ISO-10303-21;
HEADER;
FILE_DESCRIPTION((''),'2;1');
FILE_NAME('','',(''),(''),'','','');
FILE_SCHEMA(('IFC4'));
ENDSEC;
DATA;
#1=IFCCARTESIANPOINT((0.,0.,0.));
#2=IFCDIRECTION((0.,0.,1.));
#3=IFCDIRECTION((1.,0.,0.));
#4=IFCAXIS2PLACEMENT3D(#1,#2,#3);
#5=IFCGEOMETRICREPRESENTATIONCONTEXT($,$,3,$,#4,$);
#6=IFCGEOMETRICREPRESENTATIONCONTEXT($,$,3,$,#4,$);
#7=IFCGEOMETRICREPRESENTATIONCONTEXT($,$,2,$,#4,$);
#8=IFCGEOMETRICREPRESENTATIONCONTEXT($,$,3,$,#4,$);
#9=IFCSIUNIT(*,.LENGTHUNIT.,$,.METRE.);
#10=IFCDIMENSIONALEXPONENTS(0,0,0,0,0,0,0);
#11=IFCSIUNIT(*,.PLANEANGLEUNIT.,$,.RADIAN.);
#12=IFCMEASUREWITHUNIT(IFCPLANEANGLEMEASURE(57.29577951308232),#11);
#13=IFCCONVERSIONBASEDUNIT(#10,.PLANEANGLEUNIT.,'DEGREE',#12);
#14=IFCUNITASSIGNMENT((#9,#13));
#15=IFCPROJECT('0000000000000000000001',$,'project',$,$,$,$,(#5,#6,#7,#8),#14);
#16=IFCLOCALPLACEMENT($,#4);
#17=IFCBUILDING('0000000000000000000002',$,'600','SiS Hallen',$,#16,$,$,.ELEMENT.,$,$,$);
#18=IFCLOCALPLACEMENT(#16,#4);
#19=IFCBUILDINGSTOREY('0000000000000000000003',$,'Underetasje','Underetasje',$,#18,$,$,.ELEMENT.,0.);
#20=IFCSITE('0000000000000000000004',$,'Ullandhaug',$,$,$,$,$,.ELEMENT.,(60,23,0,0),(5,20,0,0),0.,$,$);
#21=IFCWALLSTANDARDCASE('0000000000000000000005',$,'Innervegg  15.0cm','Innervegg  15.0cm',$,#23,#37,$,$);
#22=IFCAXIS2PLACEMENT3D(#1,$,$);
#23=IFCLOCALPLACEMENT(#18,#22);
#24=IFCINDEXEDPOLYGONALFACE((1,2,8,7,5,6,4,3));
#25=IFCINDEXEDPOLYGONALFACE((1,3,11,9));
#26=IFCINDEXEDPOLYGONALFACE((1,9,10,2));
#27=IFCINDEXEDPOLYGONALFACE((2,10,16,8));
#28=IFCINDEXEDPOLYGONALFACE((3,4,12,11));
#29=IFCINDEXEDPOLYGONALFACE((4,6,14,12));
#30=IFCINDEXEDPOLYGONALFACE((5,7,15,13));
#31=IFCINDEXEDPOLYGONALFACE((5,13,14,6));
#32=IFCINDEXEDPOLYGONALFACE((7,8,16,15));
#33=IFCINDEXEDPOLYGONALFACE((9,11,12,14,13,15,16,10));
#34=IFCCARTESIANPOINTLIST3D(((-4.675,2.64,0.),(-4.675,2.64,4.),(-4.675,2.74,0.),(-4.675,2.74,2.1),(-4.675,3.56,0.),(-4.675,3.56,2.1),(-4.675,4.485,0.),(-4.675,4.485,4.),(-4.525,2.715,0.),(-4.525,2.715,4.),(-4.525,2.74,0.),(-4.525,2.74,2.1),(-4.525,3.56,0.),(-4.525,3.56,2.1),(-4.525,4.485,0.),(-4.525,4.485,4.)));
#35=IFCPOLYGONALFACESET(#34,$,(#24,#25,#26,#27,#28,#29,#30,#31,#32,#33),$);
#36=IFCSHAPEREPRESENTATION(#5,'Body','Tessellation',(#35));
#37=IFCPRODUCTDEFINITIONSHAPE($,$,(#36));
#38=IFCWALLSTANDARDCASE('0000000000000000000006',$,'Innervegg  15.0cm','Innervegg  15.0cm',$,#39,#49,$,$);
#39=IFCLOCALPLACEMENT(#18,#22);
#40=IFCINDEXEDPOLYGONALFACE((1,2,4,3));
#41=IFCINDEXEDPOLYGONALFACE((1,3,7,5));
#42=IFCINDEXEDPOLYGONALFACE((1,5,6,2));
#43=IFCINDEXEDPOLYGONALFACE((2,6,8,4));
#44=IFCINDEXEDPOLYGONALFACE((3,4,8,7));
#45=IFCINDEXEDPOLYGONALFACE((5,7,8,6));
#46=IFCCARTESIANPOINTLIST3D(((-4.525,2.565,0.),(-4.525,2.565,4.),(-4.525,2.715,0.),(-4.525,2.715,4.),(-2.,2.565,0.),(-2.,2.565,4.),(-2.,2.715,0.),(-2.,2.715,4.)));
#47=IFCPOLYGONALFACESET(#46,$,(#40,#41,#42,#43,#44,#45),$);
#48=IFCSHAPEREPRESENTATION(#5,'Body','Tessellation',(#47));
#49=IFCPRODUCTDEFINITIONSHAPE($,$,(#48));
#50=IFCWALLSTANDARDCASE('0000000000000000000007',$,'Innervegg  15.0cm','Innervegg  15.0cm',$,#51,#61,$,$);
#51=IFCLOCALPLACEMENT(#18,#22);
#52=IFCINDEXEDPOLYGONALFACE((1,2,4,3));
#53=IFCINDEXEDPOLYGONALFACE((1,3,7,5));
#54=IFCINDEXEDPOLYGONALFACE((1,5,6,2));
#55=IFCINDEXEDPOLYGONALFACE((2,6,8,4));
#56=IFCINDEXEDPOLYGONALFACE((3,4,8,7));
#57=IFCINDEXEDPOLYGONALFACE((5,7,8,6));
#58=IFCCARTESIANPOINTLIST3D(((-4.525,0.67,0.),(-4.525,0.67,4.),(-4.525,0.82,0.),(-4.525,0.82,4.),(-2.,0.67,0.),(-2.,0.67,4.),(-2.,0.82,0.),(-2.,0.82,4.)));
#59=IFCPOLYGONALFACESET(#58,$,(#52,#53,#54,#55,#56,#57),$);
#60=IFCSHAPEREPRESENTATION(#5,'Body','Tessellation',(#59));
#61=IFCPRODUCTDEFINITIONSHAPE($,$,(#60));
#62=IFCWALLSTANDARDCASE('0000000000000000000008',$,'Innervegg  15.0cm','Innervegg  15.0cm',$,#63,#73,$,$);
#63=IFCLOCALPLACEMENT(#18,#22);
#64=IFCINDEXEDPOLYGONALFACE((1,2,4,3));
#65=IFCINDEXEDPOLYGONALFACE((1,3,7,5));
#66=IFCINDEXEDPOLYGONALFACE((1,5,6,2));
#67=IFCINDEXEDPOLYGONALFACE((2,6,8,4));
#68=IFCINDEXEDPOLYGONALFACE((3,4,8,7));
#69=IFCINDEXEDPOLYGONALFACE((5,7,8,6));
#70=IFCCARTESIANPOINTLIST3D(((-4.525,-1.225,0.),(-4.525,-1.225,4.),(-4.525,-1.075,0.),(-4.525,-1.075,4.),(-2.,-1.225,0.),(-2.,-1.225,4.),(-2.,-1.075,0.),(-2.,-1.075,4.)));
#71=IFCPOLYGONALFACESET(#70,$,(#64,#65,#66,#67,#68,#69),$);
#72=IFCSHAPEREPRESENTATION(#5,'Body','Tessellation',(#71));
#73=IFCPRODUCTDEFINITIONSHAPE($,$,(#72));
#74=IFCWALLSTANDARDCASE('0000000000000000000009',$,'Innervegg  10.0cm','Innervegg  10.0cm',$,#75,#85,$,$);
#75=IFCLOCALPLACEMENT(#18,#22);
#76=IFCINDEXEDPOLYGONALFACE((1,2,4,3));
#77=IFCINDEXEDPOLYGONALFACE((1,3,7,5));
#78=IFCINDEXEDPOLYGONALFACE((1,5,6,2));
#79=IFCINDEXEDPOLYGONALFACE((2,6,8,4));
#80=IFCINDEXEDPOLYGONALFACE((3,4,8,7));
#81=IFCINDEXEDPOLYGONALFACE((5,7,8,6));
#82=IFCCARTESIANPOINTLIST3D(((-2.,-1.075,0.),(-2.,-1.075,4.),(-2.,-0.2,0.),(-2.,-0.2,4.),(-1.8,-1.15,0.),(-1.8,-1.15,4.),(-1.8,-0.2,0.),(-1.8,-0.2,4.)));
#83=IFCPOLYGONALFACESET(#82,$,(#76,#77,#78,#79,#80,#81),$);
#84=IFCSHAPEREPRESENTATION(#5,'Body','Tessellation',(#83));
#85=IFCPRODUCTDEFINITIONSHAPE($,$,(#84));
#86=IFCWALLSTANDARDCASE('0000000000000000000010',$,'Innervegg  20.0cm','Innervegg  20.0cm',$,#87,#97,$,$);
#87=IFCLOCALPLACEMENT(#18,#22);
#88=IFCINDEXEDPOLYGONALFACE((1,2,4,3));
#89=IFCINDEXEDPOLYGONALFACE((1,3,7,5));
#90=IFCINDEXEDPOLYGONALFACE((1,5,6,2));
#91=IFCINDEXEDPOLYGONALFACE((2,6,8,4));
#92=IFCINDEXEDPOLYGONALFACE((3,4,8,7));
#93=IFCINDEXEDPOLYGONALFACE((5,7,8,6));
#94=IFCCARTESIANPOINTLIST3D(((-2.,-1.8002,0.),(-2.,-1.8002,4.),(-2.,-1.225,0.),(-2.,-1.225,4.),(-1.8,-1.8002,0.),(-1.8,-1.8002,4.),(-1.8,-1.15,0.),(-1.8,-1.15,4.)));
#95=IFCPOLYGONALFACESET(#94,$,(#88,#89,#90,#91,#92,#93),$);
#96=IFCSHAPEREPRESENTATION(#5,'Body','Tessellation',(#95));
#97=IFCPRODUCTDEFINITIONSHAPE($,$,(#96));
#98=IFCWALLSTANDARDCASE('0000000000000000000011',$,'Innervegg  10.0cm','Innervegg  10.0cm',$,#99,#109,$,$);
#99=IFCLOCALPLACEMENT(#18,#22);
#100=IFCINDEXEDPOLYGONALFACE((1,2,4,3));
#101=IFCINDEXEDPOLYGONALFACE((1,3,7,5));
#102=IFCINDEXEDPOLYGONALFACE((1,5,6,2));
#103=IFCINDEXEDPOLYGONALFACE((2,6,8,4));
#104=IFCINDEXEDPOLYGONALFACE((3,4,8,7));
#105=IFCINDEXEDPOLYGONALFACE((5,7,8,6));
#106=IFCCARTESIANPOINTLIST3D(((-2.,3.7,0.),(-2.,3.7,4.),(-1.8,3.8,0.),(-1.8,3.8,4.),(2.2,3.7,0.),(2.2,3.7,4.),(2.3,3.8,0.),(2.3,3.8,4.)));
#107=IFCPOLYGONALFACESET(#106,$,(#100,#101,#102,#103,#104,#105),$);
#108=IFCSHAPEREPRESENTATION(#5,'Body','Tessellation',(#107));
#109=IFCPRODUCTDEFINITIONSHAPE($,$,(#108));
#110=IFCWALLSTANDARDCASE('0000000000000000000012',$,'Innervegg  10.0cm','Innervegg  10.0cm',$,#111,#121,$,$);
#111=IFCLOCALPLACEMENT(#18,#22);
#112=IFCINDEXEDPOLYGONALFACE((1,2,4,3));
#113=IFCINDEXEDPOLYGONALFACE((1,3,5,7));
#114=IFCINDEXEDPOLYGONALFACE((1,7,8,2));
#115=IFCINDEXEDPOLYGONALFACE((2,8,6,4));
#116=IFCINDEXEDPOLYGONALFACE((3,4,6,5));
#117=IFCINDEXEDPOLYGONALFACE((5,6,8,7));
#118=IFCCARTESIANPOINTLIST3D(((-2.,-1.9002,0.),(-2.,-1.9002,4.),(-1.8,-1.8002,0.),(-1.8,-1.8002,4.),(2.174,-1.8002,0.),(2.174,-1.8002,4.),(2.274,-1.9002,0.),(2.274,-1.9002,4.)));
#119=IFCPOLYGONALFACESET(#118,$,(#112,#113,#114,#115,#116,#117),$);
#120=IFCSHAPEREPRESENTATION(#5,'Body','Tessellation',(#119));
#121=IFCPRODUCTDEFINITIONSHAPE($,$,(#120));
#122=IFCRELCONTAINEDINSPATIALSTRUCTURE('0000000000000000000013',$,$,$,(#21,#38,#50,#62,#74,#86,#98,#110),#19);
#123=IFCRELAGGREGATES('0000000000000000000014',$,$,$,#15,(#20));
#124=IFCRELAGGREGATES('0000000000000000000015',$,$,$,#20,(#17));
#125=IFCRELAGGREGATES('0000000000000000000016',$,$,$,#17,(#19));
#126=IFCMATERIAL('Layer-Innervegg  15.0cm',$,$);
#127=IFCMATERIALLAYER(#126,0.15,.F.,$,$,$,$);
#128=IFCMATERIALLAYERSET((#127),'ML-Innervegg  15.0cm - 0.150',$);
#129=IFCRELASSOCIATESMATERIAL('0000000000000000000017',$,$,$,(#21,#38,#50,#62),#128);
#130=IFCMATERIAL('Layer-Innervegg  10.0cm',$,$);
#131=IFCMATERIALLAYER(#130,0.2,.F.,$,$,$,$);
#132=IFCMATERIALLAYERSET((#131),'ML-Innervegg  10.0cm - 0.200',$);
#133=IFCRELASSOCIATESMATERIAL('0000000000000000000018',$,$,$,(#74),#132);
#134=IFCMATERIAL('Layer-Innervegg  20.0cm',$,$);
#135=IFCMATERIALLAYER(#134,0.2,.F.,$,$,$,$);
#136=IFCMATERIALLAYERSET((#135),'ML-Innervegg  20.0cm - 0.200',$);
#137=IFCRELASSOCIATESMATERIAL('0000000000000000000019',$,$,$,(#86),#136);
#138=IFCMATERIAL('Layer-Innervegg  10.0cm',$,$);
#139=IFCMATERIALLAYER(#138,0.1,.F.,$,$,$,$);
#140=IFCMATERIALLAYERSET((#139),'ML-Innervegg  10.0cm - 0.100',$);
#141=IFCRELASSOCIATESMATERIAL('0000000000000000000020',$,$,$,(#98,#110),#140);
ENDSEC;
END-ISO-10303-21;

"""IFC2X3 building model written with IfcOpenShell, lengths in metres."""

from ifc_helpers import new_model, entity, si_unit, converted_unit, frame, origin_with_axes, place, context, project, spatial, polyline, outline, extrude, material, layer, layer_set, layer_usage, element, save


model = new_model("IFC2X3")

# Units and contexts
context_of_model_1 = context(None, 3, world=origin_with_axes())
context_of_model_2 = context(None, 3, world=origin_with_axes())
context_of_model_3 = context(None, 2, world=origin_with_axes())
context_of_model_4 = context(None, 3, world=origin_with_axes())
ifc_project = project(units=[si_unit("LENGTHUNIT", "METRE"), converted_unit("PLANEANGLEUNIT", "DEGREE", entity("IfcPlaneAngleMeasure", 57.29577951308232), si_unit("PLANEANGLEUNIT", "RADIAN"), dimensions=[0, 0, 0, 0, 0, 0, 0])], contexts=[context_of_model_1, context_of_model_2, context_of_model_3, context_of_model_4])

# Site, building, storey
site = spatial("IfcSite", under=ifc_project, Name="Ullandhaug", CompositionType="ELEMENT", RefLatitude=(60, 23, 0, 0), RefLongitude=(5, 20, 0, 0), RefElevation=0.0)
building_placement = place(None, origin_with_axes())
building = spatial("IfcBuilding", under=site, at=building_placement, Name="600", Description="SiS Hallen", CompositionType="ELEMENT")
storey_placement = place(building_placement, origin_with_axes())
storey = spatial("IfcBuildingStorey", under=building, at=storey_placement, Name="Underetasje", Description="Underetasje", CompositionType="ELEMENT", Elevation=0.0)

# Shared definitions
ifc_material_1 = material(Name="Layer-Innervegg  15.0cm")
ifc_layer_1 = layer(ifc_material_1, 0.15, ventilated=False)
ifc_layer_set_1 = layer_set([ifc_layer_1], Name="ML-Innervegg  15.0cm - 0.150")
ifc_layer_usage_1 = layer_usage(ifc_layer_set_1, "AXIS2", "POSITIVE", 0.0)

# Shared definitions
ifc_material_2 = material(Name="Layer-Innervegg  10.0cm")
ifc_layer_2 = layer(ifc_material_2, 0.1, ventilated=False)
ifc_layer_set_2 = layer_set([ifc_layer_2], Name="ML-Innervegg  10.0cm - 0.100")
ifc_layer_usage_2 = layer_usage(ifc_layer_set_2, "AXIS2", "POSITIVE", 0.0)

# Wall, opening
wall_1_placement = place(storey_placement, frame((-4.525, 2.715, 0.0), z_axis=(0.0, 0.0, 1.0), x_axis=(0.0, 1.0, 0.0)))
wall_1 = element("IfcWallStandardCase", 1, at=wall_1_placement, inside=storey, material=ifc_layer_usage_1, Name="Innervegg  15.0cm", Description="Innervegg  15.0cm", context=context_of_model_1, shape_type="SweptSolid", body=[
    extrude(outline(polyline([(0.0, 0.0), (1.77, 0.0), (1.77, 0.15), (-0.075, 0.15), (0.0, 0.0)])), frame((0.0, 0.0, 0.0), z_axis=(0.0, 0.0, 1.0), x_axis=(1.0, 0.0, 0.0)), (0.0, 0.0, 1.0), 4.0),
])
opening_1_placement = place(wall_1_placement, frame((0.025, 0.15, 0.0), z_axis=(0.0, 0.0, 1.0), x_axis=(1.0, 0.0, 0.0)))
element("IfcOpeningElement", 2, at=opening_1_placement, cuts=wall_1, context=context_of_model_1, shape_type="SweptSolid", body=[
    extrude(outline(polyline([(0.0, 0.0), (2.1, 0.0), (2.1, 0.82), (0.0, 0.82), (0.0, 0.0)])), frame((0.0, 0.0, 0.0), z_axis=(0.0, 1.0, 0.0), x_axis=(0.0, 0.0, 1.0)), (0.0, 0.0, -1.0), 0.15),
])

# Walls
wall_2_placement = place(storey_placement, frame((-4.525, 2.565, 0.0), z_axis=(0.0, 0.0, 1.0), x_axis=(1.0, 0.0, 0.0)))
element("IfcWallStandardCase", 3, at=wall_2_placement, inside=storey, material=ifc_layer_usage_1, Name="Innervegg  15.0cm", Description="Innervegg  15.0cm", context=context_of_model_1, shape_type="SweptSolid", body=[
    extrude(outline(polyline([(0.0, 0.0), (2.525, 0.0), (2.525, 0.15), (0.0, 0.15), (0.0, 0.0)])), origin_with_axes(), (0.0, 0.0, 1.0), 4.0),
])
for number, where, z_axis, x_axis, name in (
    (4, (-4.525, 0.67, 0.0), (0.0, 0.0, 1.0), (1.0, 0.0, 0.0), "Innervegg  15.0cm"),
    (5, (-4.525, -1.225, 0.0), (0.0, 0.0, 1.0), (1.0, 0.0, 0.0), "Innervegg  15.0cm"),
):
    element("IfcWallStandardCase", number, at=place(storey_placement, frame(where, z_axis=z_axis, x_axis=x_axis)), inside=storey, material=ifc_layer_usage_1, Name=name, Description="Innervegg  15.0cm", context=context_of_model_1, shape_type="SweptSolid", body=[
        extrude(outline(polyline([(0.0, 0.0), (2.525, 0.0), (2.525, 0.15), (0.0, 0.15), (0.0, 0.0)])), origin_with_axes(), (0.0, 0.0, 1.0), 4.0),
    ])
ifc_material_3 = material(Name="Layer-Innervegg  10.0cm")
ifc_layer_3 = layer(ifc_material_3, 0.2, ventilated=False)
ifc_layer_set_3 = layer_set([ifc_layer_3], Name="ML-Innervegg  10.0cm - 0.200")
ifc_layer_usage_3 = layer_usage(ifc_layer_set_3, "AXIS2", "POSITIVE", 0.0)
wall_3_placement = place(storey_placement, frame((-1.8, -1.15, 0.0), z_axis=(0.0, 0.0, 1.0), x_axis=(0.0, 1.0, 0.0)))
element("IfcWallStandardCase", 6, at=wall_3_placement, inside=storey, material=ifc_layer_usage_3, Name="Innervegg  10.0cm", Description="Innervegg  10.0cm", context=context_of_model_1, shape_type="SweptSolid", body=[
    extrude(outline(polyline([(0.0, 0.0), (0.95, 0.0), (0.95, 0.2), (0.075, 0.2), (0.0, 0.0)])), frame((0.0, 0.0, 0.0), z_axis=(0.0, 0.0, 1.0), x_axis=(1.0, 0.0, 0.0)), (0.0, 0.0, 1.0), 4.0),
])
ifc_material_4 = material(Name="Layer-Innervegg  20.0cm")
ifc_layer_4 = layer(ifc_material_4, 0.2, ventilated=False)
ifc_layer_set_4 = layer_set([ifc_layer_4], Name="ML-Innervegg  20.0cm - 0.200")
ifc_layer_usage_4 = layer_usage(ifc_layer_set_4, "AXIS2", "POSITIVE", 0.0)
wall_4_placement = place(storey_placement, frame((-1.8, -1.8002, 0.0), z_axis=(0.0, 0.0, 1.0), x_axis=(0.0, 1.0, 0.0)))
element("IfcWallStandardCase", 7, at=wall_4_placement, inside=storey, material=ifc_layer_usage_4, Name="Innervegg  20.0cm", Description="Innervegg  20.0cm", context=context_of_model_1, shape_type="SweptSolid", body=[
    extrude(outline(polyline([(0.0, 0.0), (0.6502, 0.0), (0.5752, 0.2), (0.0, 0.2), (0.0, 0.0)])), frame((0.0, 0.0, 0.0), z_axis=(0.0, 0.0, 1.0), x_axis=(1.0, 0.0, 0.0)), (0.0, 0.0, 1.0), 4.0),
])
wall_5_placement = place(storey_placement, frame((-2.0, 3.7, 0.0), z_axis=(0.0, 0.0, 1.0), x_axis=(1.0, 0.0, 0.0)))
element("IfcWallStandardCase", 8, at=wall_5_placement, inside=storey, material=ifc_layer_usage_2, Name="Innervegg  10.0cm", Description="Innervegg  10.0cm", context=context_of_model_1, shape_type="SweptSolid", body=[
    extrude(outline(polyline([(0.0, 0.0), (4.2, 0.0), (4.3, 0.1), (0.2, 0.1), (0.0, 0.0)])), origin_with_axes(), (0.0, 0.0, 1.0), 4.0),
])
wall_6_placement = place(storey_placement, frame((-2.0, -1.9002, 0.0), z_axis=(0.0, 0.0, 1.0), x_axis=(1.0, 0.0, 0.0)))
element("IfcWallStandardCase", 9, at=wall_6_placement, inside=storey, material=ifc_layer_usage_2, Name="Innervegg  10.0cm", Description="Innervegg  10.0cm", context=context_of_model_1, shape_type="SweptSolid", body=[
    extrude(outline(polyline([(0.0, 0.0), (4.274, 0.0), (4.174, 0.1), (0.2, 0.1), (0.0, 0.0)])), origin_with_axes(), (0.0, 0.0, 1.0), 4.0),
])

save(model, "model.ifc")
